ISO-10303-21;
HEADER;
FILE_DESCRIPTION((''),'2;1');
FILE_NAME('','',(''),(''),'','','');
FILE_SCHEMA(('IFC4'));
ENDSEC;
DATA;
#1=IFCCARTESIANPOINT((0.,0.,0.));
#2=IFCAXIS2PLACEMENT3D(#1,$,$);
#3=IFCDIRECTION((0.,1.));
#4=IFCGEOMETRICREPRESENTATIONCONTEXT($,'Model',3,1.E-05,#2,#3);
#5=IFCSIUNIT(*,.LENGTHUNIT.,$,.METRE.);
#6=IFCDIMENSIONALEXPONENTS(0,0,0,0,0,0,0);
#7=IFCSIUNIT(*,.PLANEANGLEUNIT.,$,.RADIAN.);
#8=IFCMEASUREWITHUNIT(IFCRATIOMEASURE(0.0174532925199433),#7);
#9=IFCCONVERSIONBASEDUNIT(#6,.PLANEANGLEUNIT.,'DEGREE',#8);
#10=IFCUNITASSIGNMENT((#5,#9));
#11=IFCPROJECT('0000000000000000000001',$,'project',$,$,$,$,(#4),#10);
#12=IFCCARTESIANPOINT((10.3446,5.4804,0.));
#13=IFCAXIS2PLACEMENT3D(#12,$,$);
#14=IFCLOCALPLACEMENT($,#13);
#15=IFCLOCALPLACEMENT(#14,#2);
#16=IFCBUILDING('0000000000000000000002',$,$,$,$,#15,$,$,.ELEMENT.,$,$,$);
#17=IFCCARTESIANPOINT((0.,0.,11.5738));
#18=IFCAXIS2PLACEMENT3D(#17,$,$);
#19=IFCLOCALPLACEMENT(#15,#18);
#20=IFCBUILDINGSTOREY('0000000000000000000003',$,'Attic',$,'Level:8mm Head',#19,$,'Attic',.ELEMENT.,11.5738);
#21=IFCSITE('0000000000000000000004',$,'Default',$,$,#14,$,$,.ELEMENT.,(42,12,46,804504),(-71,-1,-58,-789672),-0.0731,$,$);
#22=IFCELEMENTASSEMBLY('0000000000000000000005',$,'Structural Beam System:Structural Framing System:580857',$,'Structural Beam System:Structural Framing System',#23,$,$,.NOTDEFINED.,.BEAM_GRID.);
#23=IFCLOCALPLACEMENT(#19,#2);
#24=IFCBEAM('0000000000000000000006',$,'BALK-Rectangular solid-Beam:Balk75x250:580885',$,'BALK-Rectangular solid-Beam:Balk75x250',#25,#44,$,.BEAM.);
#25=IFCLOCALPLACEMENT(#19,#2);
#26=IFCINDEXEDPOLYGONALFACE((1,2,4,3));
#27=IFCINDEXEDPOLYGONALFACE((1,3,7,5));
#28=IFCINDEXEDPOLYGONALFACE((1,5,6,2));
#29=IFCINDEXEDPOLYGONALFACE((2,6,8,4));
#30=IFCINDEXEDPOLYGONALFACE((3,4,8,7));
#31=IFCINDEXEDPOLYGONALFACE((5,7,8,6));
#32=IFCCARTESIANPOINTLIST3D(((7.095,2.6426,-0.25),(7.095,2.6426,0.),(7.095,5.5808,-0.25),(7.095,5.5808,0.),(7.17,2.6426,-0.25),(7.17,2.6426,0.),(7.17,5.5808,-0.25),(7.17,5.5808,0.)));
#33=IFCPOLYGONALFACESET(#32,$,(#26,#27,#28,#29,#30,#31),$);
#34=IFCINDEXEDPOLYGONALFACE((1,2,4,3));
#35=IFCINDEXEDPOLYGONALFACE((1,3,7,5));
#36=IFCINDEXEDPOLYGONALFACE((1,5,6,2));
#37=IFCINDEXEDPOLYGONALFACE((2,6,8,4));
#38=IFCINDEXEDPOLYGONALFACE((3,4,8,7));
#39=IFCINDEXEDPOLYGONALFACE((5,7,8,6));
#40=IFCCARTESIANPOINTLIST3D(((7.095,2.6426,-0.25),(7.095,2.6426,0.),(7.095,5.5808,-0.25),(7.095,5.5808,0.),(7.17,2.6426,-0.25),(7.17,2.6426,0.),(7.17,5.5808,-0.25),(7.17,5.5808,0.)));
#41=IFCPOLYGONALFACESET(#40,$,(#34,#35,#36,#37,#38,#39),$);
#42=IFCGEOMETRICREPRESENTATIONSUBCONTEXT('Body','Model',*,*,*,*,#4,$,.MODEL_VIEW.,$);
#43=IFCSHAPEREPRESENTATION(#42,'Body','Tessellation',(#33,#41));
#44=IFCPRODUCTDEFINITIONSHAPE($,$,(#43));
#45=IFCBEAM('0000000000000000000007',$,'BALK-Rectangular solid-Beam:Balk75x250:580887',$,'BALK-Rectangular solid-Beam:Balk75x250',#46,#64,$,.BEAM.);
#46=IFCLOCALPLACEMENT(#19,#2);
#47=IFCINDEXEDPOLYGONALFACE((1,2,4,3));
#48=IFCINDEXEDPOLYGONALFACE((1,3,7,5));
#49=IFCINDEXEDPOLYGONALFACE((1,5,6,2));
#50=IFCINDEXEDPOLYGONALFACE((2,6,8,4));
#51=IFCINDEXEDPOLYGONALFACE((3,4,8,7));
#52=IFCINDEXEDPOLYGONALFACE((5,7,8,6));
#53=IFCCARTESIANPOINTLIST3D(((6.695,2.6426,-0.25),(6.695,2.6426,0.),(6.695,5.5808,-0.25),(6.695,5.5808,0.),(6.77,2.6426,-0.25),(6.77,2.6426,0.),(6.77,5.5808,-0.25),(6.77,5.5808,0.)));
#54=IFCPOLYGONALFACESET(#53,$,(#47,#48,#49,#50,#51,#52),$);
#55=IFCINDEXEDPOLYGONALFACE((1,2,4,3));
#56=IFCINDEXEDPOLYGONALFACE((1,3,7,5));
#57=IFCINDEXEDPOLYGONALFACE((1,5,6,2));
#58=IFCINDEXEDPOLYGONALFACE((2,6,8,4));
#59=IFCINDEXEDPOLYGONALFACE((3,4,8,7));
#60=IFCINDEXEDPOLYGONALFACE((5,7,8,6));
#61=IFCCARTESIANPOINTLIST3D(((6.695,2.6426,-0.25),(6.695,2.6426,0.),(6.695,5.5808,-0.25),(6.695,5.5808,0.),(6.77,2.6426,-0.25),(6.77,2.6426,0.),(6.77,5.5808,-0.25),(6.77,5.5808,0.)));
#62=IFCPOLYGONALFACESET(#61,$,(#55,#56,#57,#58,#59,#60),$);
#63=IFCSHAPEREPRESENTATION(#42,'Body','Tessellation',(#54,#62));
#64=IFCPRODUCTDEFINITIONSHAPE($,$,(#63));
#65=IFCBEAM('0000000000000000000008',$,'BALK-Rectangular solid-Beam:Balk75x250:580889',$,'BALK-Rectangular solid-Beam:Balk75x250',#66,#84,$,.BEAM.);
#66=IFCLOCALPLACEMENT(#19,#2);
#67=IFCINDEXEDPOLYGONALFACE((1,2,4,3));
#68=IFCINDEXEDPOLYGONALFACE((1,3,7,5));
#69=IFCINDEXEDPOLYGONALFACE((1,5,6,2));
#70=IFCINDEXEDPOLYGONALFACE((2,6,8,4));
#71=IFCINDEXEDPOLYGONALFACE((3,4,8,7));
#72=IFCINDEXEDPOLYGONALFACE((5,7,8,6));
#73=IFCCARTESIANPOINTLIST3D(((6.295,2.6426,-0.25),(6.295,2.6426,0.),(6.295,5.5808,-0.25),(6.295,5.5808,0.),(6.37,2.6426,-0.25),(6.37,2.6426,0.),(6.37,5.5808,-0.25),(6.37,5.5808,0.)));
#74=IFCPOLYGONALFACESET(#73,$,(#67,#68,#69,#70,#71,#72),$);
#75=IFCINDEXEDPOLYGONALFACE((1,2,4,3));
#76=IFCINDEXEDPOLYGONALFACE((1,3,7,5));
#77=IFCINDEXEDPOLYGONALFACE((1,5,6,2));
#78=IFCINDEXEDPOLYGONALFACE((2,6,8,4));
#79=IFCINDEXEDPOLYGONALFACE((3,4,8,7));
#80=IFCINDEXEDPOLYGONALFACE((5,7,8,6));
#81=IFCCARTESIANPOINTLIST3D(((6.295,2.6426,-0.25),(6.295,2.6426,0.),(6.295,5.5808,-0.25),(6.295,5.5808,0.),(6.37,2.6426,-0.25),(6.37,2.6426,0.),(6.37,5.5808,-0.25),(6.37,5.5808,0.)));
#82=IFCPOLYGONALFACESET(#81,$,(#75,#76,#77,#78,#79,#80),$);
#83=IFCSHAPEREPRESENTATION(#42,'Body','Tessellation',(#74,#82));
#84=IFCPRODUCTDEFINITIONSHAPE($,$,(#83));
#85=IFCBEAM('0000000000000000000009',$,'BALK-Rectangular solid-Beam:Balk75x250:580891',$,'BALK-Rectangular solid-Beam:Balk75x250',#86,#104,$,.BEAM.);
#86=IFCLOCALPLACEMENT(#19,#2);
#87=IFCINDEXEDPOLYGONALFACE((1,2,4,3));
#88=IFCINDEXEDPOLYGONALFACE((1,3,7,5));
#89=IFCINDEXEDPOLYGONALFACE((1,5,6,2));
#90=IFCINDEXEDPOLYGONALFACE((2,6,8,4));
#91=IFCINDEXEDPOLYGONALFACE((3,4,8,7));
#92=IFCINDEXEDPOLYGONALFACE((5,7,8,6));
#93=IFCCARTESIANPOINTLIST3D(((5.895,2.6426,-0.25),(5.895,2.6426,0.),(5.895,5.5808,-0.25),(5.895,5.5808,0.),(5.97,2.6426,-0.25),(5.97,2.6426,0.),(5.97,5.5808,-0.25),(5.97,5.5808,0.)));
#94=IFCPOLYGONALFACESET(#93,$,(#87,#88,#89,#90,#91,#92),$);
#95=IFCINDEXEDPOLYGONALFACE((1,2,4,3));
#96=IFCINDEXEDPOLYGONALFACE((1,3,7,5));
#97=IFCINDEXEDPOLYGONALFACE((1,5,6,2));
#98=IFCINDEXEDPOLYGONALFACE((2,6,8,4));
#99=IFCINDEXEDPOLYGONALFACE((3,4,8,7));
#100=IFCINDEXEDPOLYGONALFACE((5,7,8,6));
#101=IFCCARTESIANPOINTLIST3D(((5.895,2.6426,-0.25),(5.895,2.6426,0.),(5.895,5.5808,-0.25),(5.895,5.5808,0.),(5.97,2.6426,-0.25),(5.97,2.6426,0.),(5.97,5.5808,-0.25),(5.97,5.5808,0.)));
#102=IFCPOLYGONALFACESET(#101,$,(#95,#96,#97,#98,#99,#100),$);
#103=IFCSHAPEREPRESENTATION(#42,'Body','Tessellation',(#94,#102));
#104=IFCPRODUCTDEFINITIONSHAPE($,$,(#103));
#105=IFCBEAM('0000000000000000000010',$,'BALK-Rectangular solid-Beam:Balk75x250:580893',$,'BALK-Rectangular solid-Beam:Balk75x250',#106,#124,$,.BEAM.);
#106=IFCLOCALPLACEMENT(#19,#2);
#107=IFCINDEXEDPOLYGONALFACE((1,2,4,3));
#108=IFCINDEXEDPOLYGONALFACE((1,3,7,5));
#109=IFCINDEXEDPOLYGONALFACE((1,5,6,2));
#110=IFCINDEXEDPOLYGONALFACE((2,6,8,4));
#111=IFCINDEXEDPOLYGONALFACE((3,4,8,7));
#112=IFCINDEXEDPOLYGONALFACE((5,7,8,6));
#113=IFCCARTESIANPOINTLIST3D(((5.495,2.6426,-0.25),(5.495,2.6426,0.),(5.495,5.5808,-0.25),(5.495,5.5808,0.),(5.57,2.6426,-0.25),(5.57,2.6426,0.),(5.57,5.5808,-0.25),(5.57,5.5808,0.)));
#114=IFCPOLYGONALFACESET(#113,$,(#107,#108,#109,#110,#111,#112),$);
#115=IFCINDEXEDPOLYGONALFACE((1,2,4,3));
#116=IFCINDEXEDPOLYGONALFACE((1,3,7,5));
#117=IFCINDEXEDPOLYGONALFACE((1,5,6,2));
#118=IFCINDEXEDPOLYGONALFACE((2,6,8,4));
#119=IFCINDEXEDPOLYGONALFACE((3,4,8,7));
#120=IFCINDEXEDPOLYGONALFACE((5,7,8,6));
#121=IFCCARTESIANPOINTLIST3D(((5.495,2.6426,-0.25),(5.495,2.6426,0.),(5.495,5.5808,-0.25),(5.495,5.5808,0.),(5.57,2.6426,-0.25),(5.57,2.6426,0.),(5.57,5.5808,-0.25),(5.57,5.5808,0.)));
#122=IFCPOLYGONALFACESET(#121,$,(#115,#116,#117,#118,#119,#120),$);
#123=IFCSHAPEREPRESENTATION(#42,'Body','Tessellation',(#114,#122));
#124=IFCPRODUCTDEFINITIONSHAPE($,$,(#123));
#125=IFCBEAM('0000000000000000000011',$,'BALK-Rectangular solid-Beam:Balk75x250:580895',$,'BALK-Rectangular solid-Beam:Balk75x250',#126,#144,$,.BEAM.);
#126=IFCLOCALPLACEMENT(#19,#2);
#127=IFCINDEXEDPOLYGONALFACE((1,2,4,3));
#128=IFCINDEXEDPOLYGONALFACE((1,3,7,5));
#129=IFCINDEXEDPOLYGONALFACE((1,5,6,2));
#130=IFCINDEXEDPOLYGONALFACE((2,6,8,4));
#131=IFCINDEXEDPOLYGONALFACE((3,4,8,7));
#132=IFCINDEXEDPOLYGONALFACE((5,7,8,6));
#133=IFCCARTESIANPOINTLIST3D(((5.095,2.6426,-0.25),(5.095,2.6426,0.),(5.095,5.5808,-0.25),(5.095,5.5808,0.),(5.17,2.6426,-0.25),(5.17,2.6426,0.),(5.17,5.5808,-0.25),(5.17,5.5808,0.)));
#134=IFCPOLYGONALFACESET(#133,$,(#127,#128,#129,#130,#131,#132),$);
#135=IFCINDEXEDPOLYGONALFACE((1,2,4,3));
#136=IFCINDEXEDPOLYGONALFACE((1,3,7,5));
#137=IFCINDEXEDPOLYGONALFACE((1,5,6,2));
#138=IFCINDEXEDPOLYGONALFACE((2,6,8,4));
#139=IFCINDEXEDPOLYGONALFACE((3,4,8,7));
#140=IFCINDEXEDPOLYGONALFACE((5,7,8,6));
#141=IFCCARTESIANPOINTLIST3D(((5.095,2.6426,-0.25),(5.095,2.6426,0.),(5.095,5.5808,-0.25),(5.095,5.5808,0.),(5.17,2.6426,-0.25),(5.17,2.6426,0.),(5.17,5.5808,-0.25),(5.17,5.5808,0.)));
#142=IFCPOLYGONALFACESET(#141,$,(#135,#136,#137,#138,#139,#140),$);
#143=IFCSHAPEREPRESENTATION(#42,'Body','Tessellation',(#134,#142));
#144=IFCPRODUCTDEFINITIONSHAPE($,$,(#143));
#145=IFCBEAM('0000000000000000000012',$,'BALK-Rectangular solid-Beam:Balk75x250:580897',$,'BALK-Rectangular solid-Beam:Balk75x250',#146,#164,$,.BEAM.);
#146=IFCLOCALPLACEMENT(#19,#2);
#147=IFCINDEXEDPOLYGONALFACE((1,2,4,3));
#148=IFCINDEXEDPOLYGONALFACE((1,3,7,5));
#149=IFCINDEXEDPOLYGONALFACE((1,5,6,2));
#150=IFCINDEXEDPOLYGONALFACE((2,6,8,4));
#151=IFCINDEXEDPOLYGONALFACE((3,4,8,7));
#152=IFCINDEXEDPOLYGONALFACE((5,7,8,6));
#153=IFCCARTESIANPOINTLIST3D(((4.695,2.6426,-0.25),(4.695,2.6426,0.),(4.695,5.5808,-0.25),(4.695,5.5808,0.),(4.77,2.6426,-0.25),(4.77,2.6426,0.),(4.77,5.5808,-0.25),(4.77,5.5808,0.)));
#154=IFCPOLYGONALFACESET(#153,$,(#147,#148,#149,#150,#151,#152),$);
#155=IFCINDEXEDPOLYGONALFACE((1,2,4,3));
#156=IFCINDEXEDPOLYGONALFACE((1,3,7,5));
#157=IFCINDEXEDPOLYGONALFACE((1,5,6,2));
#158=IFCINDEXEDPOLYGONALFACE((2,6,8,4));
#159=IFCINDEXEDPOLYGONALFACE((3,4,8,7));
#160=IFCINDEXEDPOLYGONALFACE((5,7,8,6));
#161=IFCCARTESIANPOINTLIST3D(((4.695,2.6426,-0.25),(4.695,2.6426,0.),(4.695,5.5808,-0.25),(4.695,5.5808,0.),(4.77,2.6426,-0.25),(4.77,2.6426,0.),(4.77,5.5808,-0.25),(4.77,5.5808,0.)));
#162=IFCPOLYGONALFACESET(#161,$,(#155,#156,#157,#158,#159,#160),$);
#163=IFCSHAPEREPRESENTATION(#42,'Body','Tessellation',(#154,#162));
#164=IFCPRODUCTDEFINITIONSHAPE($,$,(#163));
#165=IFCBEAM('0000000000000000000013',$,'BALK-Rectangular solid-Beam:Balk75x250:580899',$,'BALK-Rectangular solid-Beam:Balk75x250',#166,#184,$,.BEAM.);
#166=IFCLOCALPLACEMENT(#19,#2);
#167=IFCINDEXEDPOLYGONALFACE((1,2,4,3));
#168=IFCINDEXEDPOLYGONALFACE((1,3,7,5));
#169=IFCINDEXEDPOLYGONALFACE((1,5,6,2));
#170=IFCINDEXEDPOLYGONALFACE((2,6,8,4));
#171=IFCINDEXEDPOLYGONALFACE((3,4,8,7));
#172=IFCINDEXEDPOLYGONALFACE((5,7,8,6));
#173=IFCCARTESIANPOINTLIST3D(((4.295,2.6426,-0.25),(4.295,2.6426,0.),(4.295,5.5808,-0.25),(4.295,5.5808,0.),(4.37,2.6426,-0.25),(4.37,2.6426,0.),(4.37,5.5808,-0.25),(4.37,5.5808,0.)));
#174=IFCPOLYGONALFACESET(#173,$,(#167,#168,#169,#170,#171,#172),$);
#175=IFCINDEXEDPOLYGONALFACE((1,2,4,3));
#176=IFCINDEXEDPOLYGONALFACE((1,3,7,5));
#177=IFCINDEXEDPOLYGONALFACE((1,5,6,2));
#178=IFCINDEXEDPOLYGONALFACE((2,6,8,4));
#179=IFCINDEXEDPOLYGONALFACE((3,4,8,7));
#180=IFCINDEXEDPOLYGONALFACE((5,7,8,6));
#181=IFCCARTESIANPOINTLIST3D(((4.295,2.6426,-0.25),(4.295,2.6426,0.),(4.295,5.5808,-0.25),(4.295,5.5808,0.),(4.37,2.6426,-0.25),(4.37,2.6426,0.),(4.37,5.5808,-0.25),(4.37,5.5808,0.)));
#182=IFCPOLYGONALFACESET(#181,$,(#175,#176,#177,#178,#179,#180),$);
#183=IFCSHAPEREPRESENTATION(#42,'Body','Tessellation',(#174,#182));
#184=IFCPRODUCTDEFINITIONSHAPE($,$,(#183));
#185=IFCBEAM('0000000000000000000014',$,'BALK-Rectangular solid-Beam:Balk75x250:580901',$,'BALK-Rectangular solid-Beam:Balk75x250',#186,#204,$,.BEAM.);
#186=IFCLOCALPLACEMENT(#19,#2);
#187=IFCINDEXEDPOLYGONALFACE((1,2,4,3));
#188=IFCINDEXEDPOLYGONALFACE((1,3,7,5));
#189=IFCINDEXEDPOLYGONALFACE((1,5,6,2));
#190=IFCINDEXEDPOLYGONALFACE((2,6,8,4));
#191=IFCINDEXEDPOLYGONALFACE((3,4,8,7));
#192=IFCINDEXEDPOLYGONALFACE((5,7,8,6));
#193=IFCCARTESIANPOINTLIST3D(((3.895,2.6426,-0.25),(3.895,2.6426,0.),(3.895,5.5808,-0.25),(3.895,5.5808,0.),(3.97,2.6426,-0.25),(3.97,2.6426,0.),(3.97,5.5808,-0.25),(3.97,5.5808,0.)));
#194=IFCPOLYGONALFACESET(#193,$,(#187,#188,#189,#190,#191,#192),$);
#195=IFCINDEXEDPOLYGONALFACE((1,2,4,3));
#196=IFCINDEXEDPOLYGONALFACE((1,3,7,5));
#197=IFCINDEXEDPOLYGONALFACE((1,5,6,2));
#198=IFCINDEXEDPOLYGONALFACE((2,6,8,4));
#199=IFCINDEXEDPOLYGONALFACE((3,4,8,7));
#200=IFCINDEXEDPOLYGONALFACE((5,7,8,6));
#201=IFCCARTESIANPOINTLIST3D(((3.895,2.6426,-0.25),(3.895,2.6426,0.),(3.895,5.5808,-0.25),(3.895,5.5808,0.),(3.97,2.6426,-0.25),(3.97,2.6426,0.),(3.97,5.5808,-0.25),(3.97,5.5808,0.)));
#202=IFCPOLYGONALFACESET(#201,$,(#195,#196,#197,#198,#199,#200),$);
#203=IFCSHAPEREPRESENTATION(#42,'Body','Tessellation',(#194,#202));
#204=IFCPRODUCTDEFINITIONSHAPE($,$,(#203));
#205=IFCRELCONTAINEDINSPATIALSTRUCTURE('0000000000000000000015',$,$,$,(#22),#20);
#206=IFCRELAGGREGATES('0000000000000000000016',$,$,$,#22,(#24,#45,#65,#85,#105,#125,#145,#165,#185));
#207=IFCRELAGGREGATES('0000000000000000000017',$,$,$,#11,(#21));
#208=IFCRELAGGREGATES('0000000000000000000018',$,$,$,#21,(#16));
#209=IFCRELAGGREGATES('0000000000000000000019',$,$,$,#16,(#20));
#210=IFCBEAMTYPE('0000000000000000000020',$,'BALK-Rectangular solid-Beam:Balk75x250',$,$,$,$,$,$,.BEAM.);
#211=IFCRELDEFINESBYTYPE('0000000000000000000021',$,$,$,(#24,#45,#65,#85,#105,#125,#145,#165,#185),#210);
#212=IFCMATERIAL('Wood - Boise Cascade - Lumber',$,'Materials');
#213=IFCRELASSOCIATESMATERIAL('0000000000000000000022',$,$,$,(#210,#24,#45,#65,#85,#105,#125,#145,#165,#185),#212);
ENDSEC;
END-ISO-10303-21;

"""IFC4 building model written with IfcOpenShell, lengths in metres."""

from ifc_helpers import new_model, entity, si_unit, converted_unit, direction, frame, frame_2d, origin, origin_2d_with_axis, place, context, subcontext, project, spatial, rectangle, extrude, source, transform, mapped, material, material_profile, profile_set, profile_usage, type_object, type_shapes, element, aggregate, save


model = new_model("IFC4")

# Units and contexts
model_context = context("Model", 3, precision=1e-05, world=origin(), true_north=direction((0.0, 1.0)))
body_context = subcontext(model_context, "Body", "Model", "MODEL_VIEW")
ifc_project = project(units=[si_unit("LENGTHUNIT", "METRE"), converted_unit("PLANEANGLEUNIT", "DEGREE", entity("IfcRatioMeasure", 0.0174532925199433), si_unit("PLANEANGLEUNIT", "RADIAN"), dimensions=[0, 0, 0, 0, 0, 0, 0])], contexts=[model_context])

# Site, building, storey
site_placement = place(None, frame((10.3446, 5.4804, 0.0)))
site = spatial("IfcSite", under=ifc_project, at=site_placement, Name="Default", CompositionType="ELEMENT", RefLatitude=(42, 12, 46, 804504), RefLongitude=(-71, -1, -58, -789672), RefElevation=-0.0731)
building_placement = place(site_placement, origin())
building = spatial("IfcBuilding", under=site, at=building_placement, CompositionType="ELEMENT")
storey_placement = place(building_placement, frame((0.0, 0.0, 11.5738)))
storey = spatial("IfcBuildingStorey", under=building, at=storey_placement, Name="Attic", ObjectType="Level:8mm Head", LongName="Attic", CompositionType="ELEMENT", Elevation=11.5738)

# Shared definitions
ifc_material = material(Name="Wood - Boise Cascade - Lumber", Category="Materials")
ifc_material_profile = material_profile(ifc_material, rectangle(XDim=0.25, YDim=0.075, at=frame_2d((0.0, 0.0), x_axis=(1.0, 0.0))), Name="Balk75x250")
ifc_profile_set = profile_set([ifc_material_profile], Name="Balk75x250")

# Element assembly
assembly_1_placement = place(storey_placement, origin())
assembly_1 = element("IfcElementAssembly", 1, at=assembly_1_placement, inside=storey, Name="Structural Beam System:Structural Framing System:580857", ObjectType="Structural Beam System:Structural Framing System", AssemblyPlace="NOTDEFINED", PredefinedType="BEAM_GRID")

# Beams
beam_type_1 = type_object("IfcBeamType", Name="BALK-Rectangular solid-Beam:Balk75x250", PredefinedType="BEAM", material=ifc_profile_set)
shared_shape_1 = source(origin(), body_context, "Body", "SweptSolid", [
    extrude(rectangle(XDim=0.25, YDim=0.075, at=origin_2d_with_axis()), frame((-1.4566, 0.0, 0.0), z_axis=(1.0, 0.0, 0.0), x_axis=(0.0, 0.0, -1.0)), (0.0, 0.0, 1.0), 2.9382),
    extrude(rectangle(XDim=0.25, YDim=0.075, at=origin_2d_with_axis()), frame((-1.4566, 0.0, 0.0), z_axis=(1.0, 0.0, 0.0), x_axis=(0.0, 0.0, -1.0)), (0.0, 0.0, 1.0), 2.9382),
])
type_shapes(beam_type_1, [shared_shape_1])
ifc_profile_usage_1 = profile_usage(ifc_profile_set, cardinal=8)
beam_1_placement = place(assembly_1_placement, frame((7.1325, 4.1242, -0.125), z_axis=(0.0, 0.0, 1.0), x_axis=(0.0, -1.0, 0.0)))
beam_1 = element("IfcBeam", 2, at=beam_1_placement, type_object=beam_type_1, material=ifc_profile_usage_1, Name="BALK-Rectangular solid-Beam:Balk75x250:580885", ObjectType="BALK-Rectangular solid-Beam:Balk75x250", PredefinedType="BEAM", context=body_context, shape_type="MappedRepresentation", body=[
    mapped(shared_shape_1, transform((0.0, 0.0, 0.0), scale=1.0)),
])
ifc_profile_usage_2 = profile_usage(ifc_profile_set, cardinal=8)
beam_2_placement = place(assembly_1_placement, frame((6.7325, 4.1242, -0.125), z_axis=(0.0, 0.0, 1.0), x_axis=(0.0, -1.0, 0.0)))
beam_2 = element("IfcBeam", 3, at=beam_2_placement, type_object=beam_type_1, material=ifc_profile_usage_2, Name="BALK-Rectangular solid-Beam:Balk75x250:580887", ObjectType="BALK-Rectangular solid-Beam:Balk75x250", PredefinedType="BEAM", context=body_context, shape_type="MappedRepresentation", body=[
    mapped(shared_shape_1, transform((0.0, 0.0, 0.0), scale=1.0)),
])
ifc_profile_usage_3 = profile_usage(ifc_profile_set, cardinal=8)
beam_3_placement = place(assembly_1_placement, frame((6.3325, 4.1242, -0.125), z_axis=(0.0, 0.0, 1.0), x_axis=(0.0, -1.0, 0.0)))
beam_3 = element("IfcBeam", 4, at=beam_3_placement, type_object=beam_type_1, material=ifc_profile_usage_3, Name="BALK-Rectangular solid-Beam:Balk75x250:580889", ObjectType="BALK-Rectangular solid-Beam:Balk75x250", PredefinedType="BEAM", context=body_context, shape_type="MappedRepresentation", body=[
    mapped(shared_shape_1, transform((0.0, 0.0, 0.0), scale=1.0)),
])
ifc_profile_usage_4 = profile_usage(ifc_profile_set, cardinal=8)
beam_4_placement = place(assembly_1_placement, frame((5.9325, 4.1242, -0.125), z_axis=(0.0, 0.0, 1.0), x_axis=(0.0, -1.0, 0.0)))
beam_4 = element("IfcBeam", 5, at=beam_4_placement, type_object=beam_type_1, material=ifc_profile_usage_4, Name="BALK-Rectangular solid-Beam:Balk75x250:580891", ObjectType="BALK-Rectangular solid-Beam:Balk75x250", PredefinedType="BEAM", context=body_context, shape_type="MappedRepresentation", body=[
    mapped(shared_shape_1, transform((0.0, 0.0, 0.0), scale=1.0)),
])
ifc_profile_usage_5 = profile_usage(ifc_profile_set, cardinal=8)
beam_5_placement = place(assembly_1_placement, frame((5.5325, 4.1242, -0.125), z_axis=(0.0, 0.0, 1.0), x_axis=(0.0, -1.0, 0.0)))
beam_5 = element("IfcBeam", 6, at=beam_5_placement, type_object=beam_type_1, material=ifc_profile_usage_5, Name="BALK-Rectangular solid-Beam:Balk75x250:580893", ObjectType="BALK-Rectangular solid-Beam:Balk75x250", PredefinedType="BEAM", context=body_context, shape_type="MappedRepresentation", body=[
    mapped(shared_shape_1, transform((0.0, 0.0, 0.0), scale=1.0)),
])
ifc_profile_usage_6 = profile_usage(ifc_profile_set, cardinal=8)
beam_6_placement = place(assembly_1_placement, frame((5.1325, 4.1242, -0.125), z_axis=(0.0, 0.0, 1.0), x_axis=(0.0, -1.0, 0.0)))
beam_6 = element("IfcBeam", 7, at=beam_6_placement, type_object=beam_type_1, material=ifc_profile_usage_6, Name="BALK-Rectangular solid-Beam:Balk75x250:580895", ObjectType="BALK-Rectangular solid-Beam:Balk75x250", PredefinedType="BEAM", context=body_context, shape_type="MappedRepresentation", body=[
    mapped(shared_shape_1, transform((0.0, 0.0, 0.0), scale=1.0)),
])
ifc_profile_usage_7 = profile_usage(ifc_profile_set, cardinal=8)
beam_7_placement = place(assembly_1_placement, frame((4.7325, 4.1242, -0.125), z_axis=(0.0, 0.0, 1.0), x_axis=(0.0, -1.0, 0.0)))
beam_7 = element("IfcBeam", 8, at=beam_7_placement, type_object=beam_type_1, material=ifc_profile_usage_7, Name="BALK-Rectangular solid-Beam:Balk75x250:580897", ObjectType="BALK-Rectangular solid-Beam:Balk75x250", PredefinedType="BEAM", context=body_context, shape_type="MappedRepresentation", body=[
    mapped(shared_shape_1, transform((0.0, 0.0, 0.0), scale=1.0)),
])
ifc_profile_usage_8 = profile_usage(ifc_profile_set, cardinal=8)
beam_8_placement = place(assembly_1_placement, frame((4.3325, 4.1242, -0.125), z_axis=(0.0, 0.0, 1.0), x_axis=(0.0, -1.0, 0.0)))
beam_8 = element("IfcBeam", 9, at=beam_8_placement, type_object=beam_type_1, material=ifc_profile_usage_8, Name="BALK-Rectangular solid-Beam:Balk75x250:580899", ObjectType="BALK-Rectangular solid-Beam:Balk75x250", PredefinedType="BEAM", context=body_context, shape_type="MappedRepresentation", body=[
    mapped(shared_shape_1, transform((0.0, 0.0, 0.0), scale=1.0)),
])
ifc_profile_usage_9 = profile_usage(ifc_profile_set, cardinal=8)
beam_9_placement = place(assembly_1_placement, frame((3.9325, 4.1242, -0.125), z_axis=(0.0, 0.0, 1.0), x_axis=(0.0, -1.0, 0.0)))
beam_9 = element("IfcBeam", 10, at=beam_9_placement, type_object=beam_type_1, material=ifc_profile_usage_9, Name="BALK-Rectangular solid-Beam:Balk75x250:580901", ObjectType="BALK-Rectangular solid-Beam:Balk75x250", PredefinedType="BEAM", context=body_context, shape_type="MappedRepresentation", body=[
    mapped(shared_shape_1, transform((0.0, 0.0, 0.0), scale=1.0)),
])
aggregate(assembly_1, [beam_1, beam_2, beam_3, beam_4, beam_5, beam_6, beam_7, beam_8, beam_9])

save(model, "model.ifc")
